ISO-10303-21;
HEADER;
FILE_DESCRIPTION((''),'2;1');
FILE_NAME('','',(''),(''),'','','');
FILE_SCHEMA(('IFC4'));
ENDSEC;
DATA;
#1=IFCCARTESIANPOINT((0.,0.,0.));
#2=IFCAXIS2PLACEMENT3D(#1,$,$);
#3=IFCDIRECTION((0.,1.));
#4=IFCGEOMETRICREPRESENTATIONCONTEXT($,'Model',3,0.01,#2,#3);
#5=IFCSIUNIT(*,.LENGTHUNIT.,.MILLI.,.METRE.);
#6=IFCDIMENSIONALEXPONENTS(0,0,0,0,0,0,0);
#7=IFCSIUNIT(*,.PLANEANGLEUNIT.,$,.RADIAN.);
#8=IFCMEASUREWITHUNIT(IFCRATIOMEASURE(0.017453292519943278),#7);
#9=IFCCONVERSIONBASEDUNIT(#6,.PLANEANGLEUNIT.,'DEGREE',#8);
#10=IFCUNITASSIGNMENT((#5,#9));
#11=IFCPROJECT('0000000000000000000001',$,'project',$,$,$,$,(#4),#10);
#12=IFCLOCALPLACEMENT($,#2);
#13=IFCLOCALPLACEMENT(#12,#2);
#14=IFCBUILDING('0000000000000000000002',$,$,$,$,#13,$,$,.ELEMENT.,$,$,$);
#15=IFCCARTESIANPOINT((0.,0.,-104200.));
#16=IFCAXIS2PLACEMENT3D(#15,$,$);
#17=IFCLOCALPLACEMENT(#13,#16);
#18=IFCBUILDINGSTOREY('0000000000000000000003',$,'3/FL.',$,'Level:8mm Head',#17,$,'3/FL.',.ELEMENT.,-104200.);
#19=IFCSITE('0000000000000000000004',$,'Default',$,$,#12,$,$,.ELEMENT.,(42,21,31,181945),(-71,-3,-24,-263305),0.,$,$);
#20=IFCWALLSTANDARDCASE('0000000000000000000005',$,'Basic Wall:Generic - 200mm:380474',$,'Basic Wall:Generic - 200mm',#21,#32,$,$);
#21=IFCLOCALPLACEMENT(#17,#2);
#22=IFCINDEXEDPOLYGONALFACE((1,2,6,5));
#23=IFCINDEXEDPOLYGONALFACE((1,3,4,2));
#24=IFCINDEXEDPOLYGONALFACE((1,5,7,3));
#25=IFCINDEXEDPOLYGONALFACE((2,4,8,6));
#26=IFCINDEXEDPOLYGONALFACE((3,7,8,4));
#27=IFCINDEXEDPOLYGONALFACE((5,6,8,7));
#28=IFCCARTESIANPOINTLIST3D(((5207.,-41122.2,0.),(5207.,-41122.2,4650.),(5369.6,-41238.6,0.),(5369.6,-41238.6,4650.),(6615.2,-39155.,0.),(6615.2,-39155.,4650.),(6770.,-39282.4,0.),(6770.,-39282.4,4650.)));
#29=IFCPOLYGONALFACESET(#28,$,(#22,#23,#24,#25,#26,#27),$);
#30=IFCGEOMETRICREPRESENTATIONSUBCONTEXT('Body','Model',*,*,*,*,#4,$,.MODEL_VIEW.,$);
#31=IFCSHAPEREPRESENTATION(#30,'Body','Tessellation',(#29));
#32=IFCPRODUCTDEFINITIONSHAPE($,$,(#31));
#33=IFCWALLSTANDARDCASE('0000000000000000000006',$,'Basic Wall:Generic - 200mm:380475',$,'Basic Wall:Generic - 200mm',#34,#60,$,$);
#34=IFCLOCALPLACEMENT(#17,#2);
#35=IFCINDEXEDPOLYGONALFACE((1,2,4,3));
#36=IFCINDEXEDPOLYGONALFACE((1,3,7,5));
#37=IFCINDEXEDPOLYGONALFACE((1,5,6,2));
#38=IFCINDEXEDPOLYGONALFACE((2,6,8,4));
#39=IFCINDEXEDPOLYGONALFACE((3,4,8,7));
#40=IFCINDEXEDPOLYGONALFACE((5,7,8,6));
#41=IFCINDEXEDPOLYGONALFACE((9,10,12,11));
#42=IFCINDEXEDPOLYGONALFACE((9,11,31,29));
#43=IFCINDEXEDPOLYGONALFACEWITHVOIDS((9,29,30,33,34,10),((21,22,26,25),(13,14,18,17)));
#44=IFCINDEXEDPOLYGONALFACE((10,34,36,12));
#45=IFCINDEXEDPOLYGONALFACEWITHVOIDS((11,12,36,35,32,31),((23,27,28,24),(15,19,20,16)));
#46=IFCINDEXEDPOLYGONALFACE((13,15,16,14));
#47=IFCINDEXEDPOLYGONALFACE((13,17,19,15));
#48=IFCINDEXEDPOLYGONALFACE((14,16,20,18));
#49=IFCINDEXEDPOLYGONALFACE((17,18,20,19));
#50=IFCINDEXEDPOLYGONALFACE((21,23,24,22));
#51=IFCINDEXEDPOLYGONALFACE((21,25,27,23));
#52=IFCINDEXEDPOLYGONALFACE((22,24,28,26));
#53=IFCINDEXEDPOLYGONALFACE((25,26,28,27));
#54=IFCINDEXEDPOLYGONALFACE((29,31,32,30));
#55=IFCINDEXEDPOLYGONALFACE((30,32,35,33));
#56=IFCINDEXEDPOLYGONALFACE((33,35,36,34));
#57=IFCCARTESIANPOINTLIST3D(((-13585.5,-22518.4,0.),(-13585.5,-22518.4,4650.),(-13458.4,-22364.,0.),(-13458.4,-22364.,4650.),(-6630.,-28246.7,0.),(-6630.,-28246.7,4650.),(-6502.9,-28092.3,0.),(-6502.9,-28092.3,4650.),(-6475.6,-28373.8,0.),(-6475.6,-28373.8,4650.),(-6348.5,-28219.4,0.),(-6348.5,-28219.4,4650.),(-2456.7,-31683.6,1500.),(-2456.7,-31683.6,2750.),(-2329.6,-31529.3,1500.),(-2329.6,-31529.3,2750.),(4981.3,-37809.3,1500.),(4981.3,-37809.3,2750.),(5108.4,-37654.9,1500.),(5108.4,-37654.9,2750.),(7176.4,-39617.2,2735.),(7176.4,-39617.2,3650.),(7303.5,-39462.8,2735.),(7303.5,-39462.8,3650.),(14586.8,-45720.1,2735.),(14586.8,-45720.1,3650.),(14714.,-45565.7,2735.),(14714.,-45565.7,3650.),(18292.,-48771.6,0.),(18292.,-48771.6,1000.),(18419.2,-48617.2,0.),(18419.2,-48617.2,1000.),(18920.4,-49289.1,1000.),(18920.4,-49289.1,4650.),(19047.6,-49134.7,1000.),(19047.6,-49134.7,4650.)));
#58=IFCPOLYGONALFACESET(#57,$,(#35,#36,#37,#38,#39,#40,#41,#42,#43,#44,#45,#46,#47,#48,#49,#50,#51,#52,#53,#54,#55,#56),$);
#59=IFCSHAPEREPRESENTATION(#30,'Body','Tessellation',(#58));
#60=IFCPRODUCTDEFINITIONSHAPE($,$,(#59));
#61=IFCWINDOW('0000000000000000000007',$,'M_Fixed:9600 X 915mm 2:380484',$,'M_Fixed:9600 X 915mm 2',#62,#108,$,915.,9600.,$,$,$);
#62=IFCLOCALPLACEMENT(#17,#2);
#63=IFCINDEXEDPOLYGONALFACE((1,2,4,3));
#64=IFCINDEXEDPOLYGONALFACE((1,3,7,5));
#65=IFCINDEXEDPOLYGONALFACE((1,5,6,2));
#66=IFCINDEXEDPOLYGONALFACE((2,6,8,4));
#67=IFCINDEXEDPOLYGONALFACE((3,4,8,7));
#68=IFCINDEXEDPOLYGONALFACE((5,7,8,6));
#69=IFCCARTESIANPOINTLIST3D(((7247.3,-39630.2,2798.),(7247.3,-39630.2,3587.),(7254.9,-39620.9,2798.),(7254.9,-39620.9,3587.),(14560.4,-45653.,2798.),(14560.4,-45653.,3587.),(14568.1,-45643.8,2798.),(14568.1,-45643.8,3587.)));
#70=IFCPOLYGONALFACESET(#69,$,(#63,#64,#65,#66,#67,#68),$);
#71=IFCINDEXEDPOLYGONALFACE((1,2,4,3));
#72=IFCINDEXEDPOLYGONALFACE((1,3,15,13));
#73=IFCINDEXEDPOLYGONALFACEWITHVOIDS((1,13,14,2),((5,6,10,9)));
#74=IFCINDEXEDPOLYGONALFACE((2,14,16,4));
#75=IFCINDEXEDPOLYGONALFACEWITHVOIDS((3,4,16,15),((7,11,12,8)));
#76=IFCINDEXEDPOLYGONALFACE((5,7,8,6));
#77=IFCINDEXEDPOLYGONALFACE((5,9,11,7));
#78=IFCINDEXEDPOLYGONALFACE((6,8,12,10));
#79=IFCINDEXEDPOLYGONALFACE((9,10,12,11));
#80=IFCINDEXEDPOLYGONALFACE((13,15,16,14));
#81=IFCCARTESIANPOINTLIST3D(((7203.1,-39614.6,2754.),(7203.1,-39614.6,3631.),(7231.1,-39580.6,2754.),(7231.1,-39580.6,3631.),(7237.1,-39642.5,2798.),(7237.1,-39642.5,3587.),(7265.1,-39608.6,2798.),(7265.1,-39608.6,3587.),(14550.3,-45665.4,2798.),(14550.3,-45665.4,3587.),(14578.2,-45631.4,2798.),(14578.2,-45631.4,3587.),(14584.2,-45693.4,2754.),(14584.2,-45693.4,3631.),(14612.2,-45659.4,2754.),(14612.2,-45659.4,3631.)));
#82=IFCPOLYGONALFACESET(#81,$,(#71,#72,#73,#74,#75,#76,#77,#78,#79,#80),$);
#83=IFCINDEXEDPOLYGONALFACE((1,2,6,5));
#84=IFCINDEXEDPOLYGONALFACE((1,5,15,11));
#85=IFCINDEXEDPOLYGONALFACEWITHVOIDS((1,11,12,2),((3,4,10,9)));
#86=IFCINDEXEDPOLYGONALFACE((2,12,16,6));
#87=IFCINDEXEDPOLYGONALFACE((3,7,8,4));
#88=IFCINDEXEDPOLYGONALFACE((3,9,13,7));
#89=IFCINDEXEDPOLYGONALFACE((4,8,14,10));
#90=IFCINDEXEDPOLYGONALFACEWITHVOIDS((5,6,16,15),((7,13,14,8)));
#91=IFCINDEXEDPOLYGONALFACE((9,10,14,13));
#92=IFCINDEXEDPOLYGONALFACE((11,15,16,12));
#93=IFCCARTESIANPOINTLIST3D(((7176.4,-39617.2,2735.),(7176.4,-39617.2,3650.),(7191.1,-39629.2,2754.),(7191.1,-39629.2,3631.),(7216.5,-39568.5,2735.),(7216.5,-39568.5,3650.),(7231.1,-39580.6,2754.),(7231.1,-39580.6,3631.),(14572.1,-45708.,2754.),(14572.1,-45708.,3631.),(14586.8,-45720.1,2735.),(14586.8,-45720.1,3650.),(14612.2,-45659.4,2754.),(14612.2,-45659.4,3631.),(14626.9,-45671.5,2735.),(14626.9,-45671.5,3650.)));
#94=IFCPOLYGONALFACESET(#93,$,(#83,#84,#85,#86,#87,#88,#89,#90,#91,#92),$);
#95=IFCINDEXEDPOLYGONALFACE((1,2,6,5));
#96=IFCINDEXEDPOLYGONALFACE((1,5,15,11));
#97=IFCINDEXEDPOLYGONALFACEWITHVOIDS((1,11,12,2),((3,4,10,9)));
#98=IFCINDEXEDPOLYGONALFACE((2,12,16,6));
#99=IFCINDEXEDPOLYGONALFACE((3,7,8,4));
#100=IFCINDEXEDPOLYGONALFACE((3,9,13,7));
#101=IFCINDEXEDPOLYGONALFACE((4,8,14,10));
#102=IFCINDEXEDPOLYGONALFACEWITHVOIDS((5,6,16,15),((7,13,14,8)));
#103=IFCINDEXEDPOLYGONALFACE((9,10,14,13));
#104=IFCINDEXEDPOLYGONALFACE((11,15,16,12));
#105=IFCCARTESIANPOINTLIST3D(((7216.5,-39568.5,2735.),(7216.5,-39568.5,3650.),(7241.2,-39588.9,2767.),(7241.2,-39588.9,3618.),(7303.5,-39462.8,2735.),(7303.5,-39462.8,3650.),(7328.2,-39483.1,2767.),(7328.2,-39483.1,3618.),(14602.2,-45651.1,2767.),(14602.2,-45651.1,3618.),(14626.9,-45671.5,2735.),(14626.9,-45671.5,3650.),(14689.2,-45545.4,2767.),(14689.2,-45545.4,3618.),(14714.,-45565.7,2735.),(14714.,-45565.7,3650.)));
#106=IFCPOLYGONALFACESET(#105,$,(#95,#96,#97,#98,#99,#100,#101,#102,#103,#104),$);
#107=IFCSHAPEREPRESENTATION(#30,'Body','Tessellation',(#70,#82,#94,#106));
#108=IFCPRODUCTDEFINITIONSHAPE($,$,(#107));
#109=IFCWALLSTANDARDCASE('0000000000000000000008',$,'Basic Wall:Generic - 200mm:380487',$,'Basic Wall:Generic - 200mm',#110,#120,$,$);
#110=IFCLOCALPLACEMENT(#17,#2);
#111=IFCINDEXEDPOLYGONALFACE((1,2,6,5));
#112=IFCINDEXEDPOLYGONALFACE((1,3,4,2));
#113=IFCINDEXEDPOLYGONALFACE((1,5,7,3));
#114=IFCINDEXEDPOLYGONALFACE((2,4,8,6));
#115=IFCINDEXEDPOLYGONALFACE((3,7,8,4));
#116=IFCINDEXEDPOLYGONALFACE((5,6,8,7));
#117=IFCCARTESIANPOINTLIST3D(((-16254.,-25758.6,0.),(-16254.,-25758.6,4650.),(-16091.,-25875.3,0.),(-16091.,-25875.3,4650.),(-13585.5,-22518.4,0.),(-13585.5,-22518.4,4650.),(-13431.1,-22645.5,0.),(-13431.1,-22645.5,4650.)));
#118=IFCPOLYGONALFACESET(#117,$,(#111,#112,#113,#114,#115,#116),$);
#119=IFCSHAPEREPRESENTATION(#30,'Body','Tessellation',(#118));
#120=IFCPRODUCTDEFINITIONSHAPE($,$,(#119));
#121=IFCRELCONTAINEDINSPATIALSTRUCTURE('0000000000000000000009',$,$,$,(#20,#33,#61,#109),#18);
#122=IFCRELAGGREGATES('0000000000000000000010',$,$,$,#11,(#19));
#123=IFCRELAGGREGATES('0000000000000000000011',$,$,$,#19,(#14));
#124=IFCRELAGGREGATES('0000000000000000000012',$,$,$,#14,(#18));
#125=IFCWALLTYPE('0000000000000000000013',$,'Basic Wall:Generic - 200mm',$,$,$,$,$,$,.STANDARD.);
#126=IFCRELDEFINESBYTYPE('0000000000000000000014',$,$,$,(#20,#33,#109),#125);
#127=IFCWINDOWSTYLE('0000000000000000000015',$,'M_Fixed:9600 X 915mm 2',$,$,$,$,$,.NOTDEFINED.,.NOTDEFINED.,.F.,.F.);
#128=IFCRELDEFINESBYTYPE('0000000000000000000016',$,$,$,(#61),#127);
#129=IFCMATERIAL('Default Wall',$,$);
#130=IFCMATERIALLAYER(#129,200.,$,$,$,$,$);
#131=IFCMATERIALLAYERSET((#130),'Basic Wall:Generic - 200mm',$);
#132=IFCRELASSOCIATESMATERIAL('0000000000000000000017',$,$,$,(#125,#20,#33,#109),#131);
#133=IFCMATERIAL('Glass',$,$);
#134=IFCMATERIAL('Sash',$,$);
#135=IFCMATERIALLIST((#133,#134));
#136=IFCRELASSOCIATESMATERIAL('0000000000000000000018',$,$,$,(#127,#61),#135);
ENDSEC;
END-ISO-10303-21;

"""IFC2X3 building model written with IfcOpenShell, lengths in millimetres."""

from ifc_helpers import new_model, entity, si_unit, converted_unit, direction, frame, frame_2d, origin, origin_2d_with_axis, place, context, subcontext, project, spatial, polyline, rectangle, outline, extrude, source, transform, mapped, material, material_list, layer, layer_set, layer_usage, type_object, type_shapes, element, fill, save


model = new_model("IFC2X3")

# Units and contexts
model_context = context("Model", 3, precision=0.01, world=origin(), true_north=direction((0.0, 1.0)))
body_context = subcontext(model_context, "Body", "Model", "MODEL_VIEW")
ifc_project = project(units=[si_unit("LENGTHUNIT", "METRE", prefix="MILLI"), converted_unit("PLANEANGLEUNIT", "DEGREE", entity("IfcRatioMeasure", 0.017453292519943278), si_unit("PLANEANGLEUNIT", "RADIAN"), dimensions=[0, 0, 0, 0, 0, 0, 0])], contexts=[model_context])

# Site, building, storey
site_placement = place(None, origin())
site = spatial("IfcSite", under=ifc_project, at=site_placement, Name="Default", CompositionType="ELEMENT", RefLatitude=(42, 21, 31, 181945), RefLongitude=(-71, -3, -24, -263305), RefElevation=0.0)
building_placement = place(site_placement, origin())
building = spatial("IfcBuilding", under=site, at=building_placement, CompositionType="ELEMENT")
storey_placement = place(building_placement, frame((0.0, 0.0, -104200.0)))
storey = spatial("IfcBuildingStorey", under=building, at=storey_placement, Name="3/FL.", ObjectType="Level:8mm Head", LongName="3/FL.", CompositionType="ELEMENT", Elevation=-104200.0)

# Shared definitions
ifc_material_1 = material(Name="Default Wall")
ifc_layer = layer(ifc_material_1, 200.0)
ifc_layer_set = layer_set([ifc_layer], Name="Basic Wall:Generic - 200mm")
ifc_layer_usage = layer_usage(ifc_layer_set, "AXIS2", "NEGATIVE", 100.0)
wall_type = type_object("IfcWallType", Name="Basic Wall:Generic - 200mm", PredefinedType="STANDARD", material=ifc_layer_set)

# Shared definitions
ifc_material_2 = material(Name="Glass")
ifc_material_3 = material(Name="Sash")
ifc_material_list = material_list([ifc_material_2, ifc_material_3])

# Wall
wall_1_placement = place(storey_placement, frame((5288.3, -41180.4, 0.0), z_axis=(0.0, 0.0, 1.0), x_axis=(0.582098, 0.813119, 0.0)))
element("IfcWallStandardCase", 1, at=wall_1_placement, inside=storey, type_object=wall_type, material=ifc_layer_usage, Name="Basic Wall:Generic - 200mm:380474", ObjectType="Basic Wall:Generic - 200mm", context=body_context, shape_type="SweptSolid", body=[
    extrude(outline(polyline([(2405.7, -100.0), (2419.3, 100.0), (0.0, 100.0), (0.0, -100.0), (2405.7, -100.0)])), origin(), (0.0, 0.0, 1.0), 4650.0),
])

# Wall, openings, window
wall_2_placement = place(storey_placement, frame((-13521.9, -22441.2, 0.0), z_axis=(0.0, 0.0, 1.0), x_axis=(0.771917, -0.635723, 0.0)))
wall_2 = element("IfcWallStandardCase", 2, at=wall_2_placement, inside=storey, type_object=wall_type, material=ifc_layer_usage, Name="Basic Wall:Generic - 200mm:380475", ObjectType="Basic Wall:Generic - 200mm", context=body_context, shape_type="SweptSolid", body=[
    extrude(rectangle(XDim=42110.7, YDim=200.0, at=frame_2d((21055.3, 0.0), x_axis=(-1.0, 0.0))), origin(), (0.0, 0.0, 1.0), 4650.0),
])
opening_1_placement = place(storey_placement, frame((-13521.9, -22441.2, 0.0), z_axis=(0.0, 0.0, 1.0), x_axis=(0.771917, -0.635723, 0.0)))
element("IfcOpeningElement", 3, at=opening_1_placement, cuts=wall_2, ObjectType="Opening", context=body_context, shape_type="SweptSolid", body=[
    extrude(rectangle(XDim=4650.0, YDim=200.0, at=frame_2d((0.0, 0.0), x_axis=(1.0, 0.0))), frame((9210.7, 0.0, 2325.0), z_axis=(-1.0, 0.0, 0.0), x_axis=(0.0, 0.0, 1.0)), (0.0, 0.0, 1.0), 200.0),
])
opening_2_placement = place(wall_2_placement, origin())
element("IfcOpeningElement", 4, at=opening_2_placement, cuts=wall_2, ObjectType="Opening", context=body_context, shape_type="SweptSolid", body=[
    extrude(rectangle(XDim=1250.0, YDim=9635.8, at=origin_2d_with_axis()), frame((19234.9, -100.0, 2125.0), z_axis=(0.0, 1.0, 0.0), x_axis=(0.0, 0.0, -1.0)), (0.0, 0.0, 1.0), 200.0),
])
opening_3_placement = place(wall_2_placement, frame((-3828.6, 25918.9, 0.0), z_axis=(0.0, 0.0, 1.0), x_axis=(0.771917, 0.635723, 0.0)))
element("IfcOpeningElement", 5, at=opening_3_placement, cuts=wall_2, ObjectType="Opening", context=body_context, shape_type="SweptSolid", body=[
    extrude(rectangle(XDim=1000.0, YDim=1010.1, at=frame_2d((0.0, 0.0), x_axis=(1.0, 0.0))), frame((18673.8, -49102.4, 500.0), z_axis=(0.635723, 0.771917, 0.0), x_axis=(0.0, 0.0, -1.0)), (0.0, 0.0, 1.0), 1012.7),
])
opening_4_placement = place(wall_2_placement, frame((36496.6, 100.0, 2735.0)))
opening_4 = element("IfcOpeningElement", 6, at=opening_4_placement, cuts=wall_2, ObjectType="Opening", context=body_context, shape_type="SweptSolid", body=[
    extrude(rectangle(XDim=915.0, YDim=9600.0, at=frame_2d((457.5, 4800.0), x_axis=(1.0, 0.0))), frame((0.0, 0.0, 0.0), z_axis=(0.0, -1.0, 0.0), x_axis=(0.0, 0.0, 1.0)), (0.0, 0.0, 1.0), 200.0),
])
window_style_1 = type_object("IfcWindowStyle", Name="M_Fixed:9600 X 915mm 2", ConstructionType="NOTDEFINED", OperationType="NOTDEFINED", ParameterTakesPrecedence=False, Sizeable=False, material=ifc_material_list)
shared_shape_1 = source(origin(), body_context, "Body", "SweptSolid", [
    extrude(rectangle(XDim=12.0, YDim=9474.0, at=frame_2d((0.0, 0.0), x_axis=(1.0, 0.0))), frame((4800.0, 159.0, 63.0), z_axis=(0.0, 0.0, 1.0), x_axis=(0.0, -1.0, 0.0)), (0.0, 0.0, 1.0), 789.0),
    extrude(outline(polyline([(-4781.0, -438.5), (4781.0, -438.5), (4781.0, 438.5), (-4781.0, 438.5), (-4781.0, -438.5)]), holes=[polyline([(-4737.0, -394.5), (-4737.0, 394.5), (4737.0, 394.5), (4737.0, -394.5), (-4737.0, -394.5)])]), frame((4800.0, 137.0, 457.5), z_axis=(0.0, 1.0, 0.0), x_axis=(1.0, 0.0, 0.0)), (0.0, 0.0, 1.0), 44.0),
    extrude(outline(polyline([(-4800.0, -457.5), (4800.0, -457.5), (4800.0, 457.5), (-4800.0, 457.5), (-4800.0, -457.5)]), holes=[polyline([(-4781.0, -438.5), (-4781.0, 438.5), (4781.0, 438.5), (4781.0, -438.5), (-4781.0, -438.5)])]), frame((4800.0, 137.0, 457.5), z_axis=(0.0, 1.0, 0.0), x_axis=(1.0, 0.0, 0.0)), (0.0, 0.0, 1.0), 63.0),
    extrude(outline(polyline([(-4800.0, -457.5), (4800.0, -457.5), (4800.0, 457.5), (-4800.0, 457.5), (-4800.0, -457.5)]), holes=[polyline([(-4768.0, -425.5), (-4768.0, 425.5), (4768.0, 425.5), (4768.0, -425.5), (-4768.0, -425.5)])]), frame((4800.0, 0.0, 457.5), z_axis=(0.0, 1.0, 0.0), x_axis=(1.0, 0.0, 0.0)), (0.0, 0.0, 1.0), 137.0),
])
type_shapes(window_style_1, [shared_shape_1])
window_1_placement = place(opening_4_placement, frame((0.0, 0.0, 0.0), z_axis=(0.0, 0.0, 1.0), x_axis=(-1.0, 0.0, 0.0)))
window_1 = element("IfcWindow", 7, at=window_1_placement, inside=storey, type_object=window_style_1, material=ifc_material_list, Name="M_Fixed:9600 X 915mm 2:380484", ObjectType="M_Fixed:9600 X 915mm 2", OverallHeight=915.0, OverallWidth=9600.0, context=body_context, shape_type="MappedRepresentation", body=[
    mapped(shared_shape_1, transform((0.0, 0.0, 0.0), scale=1.0)),
])
fill(opening_4, window_1)

# Wall
wall_3_placement = place(storey_placement, frame((-16176.8, -25822.2, 0.0), z_axis=(0.0, 0.0, 1.0), x_axis=(0.635723, 0.771917, 0.0)))
element("IfcWallStandardCase", 8, at=wall_3_placement, inside=storey, type_object=wall_type, material=ifc_layer_usage, Name="Basic Wall:Generic - 200mm:380487", ObjectType="Basic Wall:Generic - 200mm", context=body_context, shape_type="SweptSolid", body=[
    extrude(outline(polyline([(4197.6, -100.0), (4197.6, 100.0), (0.0, 100.0), (13.5, -100.0), (4197.6, -100.0)])), origin(), (0.0, 0.0, 1.0), 4650.0),
])

save(model, "model.ifc")
